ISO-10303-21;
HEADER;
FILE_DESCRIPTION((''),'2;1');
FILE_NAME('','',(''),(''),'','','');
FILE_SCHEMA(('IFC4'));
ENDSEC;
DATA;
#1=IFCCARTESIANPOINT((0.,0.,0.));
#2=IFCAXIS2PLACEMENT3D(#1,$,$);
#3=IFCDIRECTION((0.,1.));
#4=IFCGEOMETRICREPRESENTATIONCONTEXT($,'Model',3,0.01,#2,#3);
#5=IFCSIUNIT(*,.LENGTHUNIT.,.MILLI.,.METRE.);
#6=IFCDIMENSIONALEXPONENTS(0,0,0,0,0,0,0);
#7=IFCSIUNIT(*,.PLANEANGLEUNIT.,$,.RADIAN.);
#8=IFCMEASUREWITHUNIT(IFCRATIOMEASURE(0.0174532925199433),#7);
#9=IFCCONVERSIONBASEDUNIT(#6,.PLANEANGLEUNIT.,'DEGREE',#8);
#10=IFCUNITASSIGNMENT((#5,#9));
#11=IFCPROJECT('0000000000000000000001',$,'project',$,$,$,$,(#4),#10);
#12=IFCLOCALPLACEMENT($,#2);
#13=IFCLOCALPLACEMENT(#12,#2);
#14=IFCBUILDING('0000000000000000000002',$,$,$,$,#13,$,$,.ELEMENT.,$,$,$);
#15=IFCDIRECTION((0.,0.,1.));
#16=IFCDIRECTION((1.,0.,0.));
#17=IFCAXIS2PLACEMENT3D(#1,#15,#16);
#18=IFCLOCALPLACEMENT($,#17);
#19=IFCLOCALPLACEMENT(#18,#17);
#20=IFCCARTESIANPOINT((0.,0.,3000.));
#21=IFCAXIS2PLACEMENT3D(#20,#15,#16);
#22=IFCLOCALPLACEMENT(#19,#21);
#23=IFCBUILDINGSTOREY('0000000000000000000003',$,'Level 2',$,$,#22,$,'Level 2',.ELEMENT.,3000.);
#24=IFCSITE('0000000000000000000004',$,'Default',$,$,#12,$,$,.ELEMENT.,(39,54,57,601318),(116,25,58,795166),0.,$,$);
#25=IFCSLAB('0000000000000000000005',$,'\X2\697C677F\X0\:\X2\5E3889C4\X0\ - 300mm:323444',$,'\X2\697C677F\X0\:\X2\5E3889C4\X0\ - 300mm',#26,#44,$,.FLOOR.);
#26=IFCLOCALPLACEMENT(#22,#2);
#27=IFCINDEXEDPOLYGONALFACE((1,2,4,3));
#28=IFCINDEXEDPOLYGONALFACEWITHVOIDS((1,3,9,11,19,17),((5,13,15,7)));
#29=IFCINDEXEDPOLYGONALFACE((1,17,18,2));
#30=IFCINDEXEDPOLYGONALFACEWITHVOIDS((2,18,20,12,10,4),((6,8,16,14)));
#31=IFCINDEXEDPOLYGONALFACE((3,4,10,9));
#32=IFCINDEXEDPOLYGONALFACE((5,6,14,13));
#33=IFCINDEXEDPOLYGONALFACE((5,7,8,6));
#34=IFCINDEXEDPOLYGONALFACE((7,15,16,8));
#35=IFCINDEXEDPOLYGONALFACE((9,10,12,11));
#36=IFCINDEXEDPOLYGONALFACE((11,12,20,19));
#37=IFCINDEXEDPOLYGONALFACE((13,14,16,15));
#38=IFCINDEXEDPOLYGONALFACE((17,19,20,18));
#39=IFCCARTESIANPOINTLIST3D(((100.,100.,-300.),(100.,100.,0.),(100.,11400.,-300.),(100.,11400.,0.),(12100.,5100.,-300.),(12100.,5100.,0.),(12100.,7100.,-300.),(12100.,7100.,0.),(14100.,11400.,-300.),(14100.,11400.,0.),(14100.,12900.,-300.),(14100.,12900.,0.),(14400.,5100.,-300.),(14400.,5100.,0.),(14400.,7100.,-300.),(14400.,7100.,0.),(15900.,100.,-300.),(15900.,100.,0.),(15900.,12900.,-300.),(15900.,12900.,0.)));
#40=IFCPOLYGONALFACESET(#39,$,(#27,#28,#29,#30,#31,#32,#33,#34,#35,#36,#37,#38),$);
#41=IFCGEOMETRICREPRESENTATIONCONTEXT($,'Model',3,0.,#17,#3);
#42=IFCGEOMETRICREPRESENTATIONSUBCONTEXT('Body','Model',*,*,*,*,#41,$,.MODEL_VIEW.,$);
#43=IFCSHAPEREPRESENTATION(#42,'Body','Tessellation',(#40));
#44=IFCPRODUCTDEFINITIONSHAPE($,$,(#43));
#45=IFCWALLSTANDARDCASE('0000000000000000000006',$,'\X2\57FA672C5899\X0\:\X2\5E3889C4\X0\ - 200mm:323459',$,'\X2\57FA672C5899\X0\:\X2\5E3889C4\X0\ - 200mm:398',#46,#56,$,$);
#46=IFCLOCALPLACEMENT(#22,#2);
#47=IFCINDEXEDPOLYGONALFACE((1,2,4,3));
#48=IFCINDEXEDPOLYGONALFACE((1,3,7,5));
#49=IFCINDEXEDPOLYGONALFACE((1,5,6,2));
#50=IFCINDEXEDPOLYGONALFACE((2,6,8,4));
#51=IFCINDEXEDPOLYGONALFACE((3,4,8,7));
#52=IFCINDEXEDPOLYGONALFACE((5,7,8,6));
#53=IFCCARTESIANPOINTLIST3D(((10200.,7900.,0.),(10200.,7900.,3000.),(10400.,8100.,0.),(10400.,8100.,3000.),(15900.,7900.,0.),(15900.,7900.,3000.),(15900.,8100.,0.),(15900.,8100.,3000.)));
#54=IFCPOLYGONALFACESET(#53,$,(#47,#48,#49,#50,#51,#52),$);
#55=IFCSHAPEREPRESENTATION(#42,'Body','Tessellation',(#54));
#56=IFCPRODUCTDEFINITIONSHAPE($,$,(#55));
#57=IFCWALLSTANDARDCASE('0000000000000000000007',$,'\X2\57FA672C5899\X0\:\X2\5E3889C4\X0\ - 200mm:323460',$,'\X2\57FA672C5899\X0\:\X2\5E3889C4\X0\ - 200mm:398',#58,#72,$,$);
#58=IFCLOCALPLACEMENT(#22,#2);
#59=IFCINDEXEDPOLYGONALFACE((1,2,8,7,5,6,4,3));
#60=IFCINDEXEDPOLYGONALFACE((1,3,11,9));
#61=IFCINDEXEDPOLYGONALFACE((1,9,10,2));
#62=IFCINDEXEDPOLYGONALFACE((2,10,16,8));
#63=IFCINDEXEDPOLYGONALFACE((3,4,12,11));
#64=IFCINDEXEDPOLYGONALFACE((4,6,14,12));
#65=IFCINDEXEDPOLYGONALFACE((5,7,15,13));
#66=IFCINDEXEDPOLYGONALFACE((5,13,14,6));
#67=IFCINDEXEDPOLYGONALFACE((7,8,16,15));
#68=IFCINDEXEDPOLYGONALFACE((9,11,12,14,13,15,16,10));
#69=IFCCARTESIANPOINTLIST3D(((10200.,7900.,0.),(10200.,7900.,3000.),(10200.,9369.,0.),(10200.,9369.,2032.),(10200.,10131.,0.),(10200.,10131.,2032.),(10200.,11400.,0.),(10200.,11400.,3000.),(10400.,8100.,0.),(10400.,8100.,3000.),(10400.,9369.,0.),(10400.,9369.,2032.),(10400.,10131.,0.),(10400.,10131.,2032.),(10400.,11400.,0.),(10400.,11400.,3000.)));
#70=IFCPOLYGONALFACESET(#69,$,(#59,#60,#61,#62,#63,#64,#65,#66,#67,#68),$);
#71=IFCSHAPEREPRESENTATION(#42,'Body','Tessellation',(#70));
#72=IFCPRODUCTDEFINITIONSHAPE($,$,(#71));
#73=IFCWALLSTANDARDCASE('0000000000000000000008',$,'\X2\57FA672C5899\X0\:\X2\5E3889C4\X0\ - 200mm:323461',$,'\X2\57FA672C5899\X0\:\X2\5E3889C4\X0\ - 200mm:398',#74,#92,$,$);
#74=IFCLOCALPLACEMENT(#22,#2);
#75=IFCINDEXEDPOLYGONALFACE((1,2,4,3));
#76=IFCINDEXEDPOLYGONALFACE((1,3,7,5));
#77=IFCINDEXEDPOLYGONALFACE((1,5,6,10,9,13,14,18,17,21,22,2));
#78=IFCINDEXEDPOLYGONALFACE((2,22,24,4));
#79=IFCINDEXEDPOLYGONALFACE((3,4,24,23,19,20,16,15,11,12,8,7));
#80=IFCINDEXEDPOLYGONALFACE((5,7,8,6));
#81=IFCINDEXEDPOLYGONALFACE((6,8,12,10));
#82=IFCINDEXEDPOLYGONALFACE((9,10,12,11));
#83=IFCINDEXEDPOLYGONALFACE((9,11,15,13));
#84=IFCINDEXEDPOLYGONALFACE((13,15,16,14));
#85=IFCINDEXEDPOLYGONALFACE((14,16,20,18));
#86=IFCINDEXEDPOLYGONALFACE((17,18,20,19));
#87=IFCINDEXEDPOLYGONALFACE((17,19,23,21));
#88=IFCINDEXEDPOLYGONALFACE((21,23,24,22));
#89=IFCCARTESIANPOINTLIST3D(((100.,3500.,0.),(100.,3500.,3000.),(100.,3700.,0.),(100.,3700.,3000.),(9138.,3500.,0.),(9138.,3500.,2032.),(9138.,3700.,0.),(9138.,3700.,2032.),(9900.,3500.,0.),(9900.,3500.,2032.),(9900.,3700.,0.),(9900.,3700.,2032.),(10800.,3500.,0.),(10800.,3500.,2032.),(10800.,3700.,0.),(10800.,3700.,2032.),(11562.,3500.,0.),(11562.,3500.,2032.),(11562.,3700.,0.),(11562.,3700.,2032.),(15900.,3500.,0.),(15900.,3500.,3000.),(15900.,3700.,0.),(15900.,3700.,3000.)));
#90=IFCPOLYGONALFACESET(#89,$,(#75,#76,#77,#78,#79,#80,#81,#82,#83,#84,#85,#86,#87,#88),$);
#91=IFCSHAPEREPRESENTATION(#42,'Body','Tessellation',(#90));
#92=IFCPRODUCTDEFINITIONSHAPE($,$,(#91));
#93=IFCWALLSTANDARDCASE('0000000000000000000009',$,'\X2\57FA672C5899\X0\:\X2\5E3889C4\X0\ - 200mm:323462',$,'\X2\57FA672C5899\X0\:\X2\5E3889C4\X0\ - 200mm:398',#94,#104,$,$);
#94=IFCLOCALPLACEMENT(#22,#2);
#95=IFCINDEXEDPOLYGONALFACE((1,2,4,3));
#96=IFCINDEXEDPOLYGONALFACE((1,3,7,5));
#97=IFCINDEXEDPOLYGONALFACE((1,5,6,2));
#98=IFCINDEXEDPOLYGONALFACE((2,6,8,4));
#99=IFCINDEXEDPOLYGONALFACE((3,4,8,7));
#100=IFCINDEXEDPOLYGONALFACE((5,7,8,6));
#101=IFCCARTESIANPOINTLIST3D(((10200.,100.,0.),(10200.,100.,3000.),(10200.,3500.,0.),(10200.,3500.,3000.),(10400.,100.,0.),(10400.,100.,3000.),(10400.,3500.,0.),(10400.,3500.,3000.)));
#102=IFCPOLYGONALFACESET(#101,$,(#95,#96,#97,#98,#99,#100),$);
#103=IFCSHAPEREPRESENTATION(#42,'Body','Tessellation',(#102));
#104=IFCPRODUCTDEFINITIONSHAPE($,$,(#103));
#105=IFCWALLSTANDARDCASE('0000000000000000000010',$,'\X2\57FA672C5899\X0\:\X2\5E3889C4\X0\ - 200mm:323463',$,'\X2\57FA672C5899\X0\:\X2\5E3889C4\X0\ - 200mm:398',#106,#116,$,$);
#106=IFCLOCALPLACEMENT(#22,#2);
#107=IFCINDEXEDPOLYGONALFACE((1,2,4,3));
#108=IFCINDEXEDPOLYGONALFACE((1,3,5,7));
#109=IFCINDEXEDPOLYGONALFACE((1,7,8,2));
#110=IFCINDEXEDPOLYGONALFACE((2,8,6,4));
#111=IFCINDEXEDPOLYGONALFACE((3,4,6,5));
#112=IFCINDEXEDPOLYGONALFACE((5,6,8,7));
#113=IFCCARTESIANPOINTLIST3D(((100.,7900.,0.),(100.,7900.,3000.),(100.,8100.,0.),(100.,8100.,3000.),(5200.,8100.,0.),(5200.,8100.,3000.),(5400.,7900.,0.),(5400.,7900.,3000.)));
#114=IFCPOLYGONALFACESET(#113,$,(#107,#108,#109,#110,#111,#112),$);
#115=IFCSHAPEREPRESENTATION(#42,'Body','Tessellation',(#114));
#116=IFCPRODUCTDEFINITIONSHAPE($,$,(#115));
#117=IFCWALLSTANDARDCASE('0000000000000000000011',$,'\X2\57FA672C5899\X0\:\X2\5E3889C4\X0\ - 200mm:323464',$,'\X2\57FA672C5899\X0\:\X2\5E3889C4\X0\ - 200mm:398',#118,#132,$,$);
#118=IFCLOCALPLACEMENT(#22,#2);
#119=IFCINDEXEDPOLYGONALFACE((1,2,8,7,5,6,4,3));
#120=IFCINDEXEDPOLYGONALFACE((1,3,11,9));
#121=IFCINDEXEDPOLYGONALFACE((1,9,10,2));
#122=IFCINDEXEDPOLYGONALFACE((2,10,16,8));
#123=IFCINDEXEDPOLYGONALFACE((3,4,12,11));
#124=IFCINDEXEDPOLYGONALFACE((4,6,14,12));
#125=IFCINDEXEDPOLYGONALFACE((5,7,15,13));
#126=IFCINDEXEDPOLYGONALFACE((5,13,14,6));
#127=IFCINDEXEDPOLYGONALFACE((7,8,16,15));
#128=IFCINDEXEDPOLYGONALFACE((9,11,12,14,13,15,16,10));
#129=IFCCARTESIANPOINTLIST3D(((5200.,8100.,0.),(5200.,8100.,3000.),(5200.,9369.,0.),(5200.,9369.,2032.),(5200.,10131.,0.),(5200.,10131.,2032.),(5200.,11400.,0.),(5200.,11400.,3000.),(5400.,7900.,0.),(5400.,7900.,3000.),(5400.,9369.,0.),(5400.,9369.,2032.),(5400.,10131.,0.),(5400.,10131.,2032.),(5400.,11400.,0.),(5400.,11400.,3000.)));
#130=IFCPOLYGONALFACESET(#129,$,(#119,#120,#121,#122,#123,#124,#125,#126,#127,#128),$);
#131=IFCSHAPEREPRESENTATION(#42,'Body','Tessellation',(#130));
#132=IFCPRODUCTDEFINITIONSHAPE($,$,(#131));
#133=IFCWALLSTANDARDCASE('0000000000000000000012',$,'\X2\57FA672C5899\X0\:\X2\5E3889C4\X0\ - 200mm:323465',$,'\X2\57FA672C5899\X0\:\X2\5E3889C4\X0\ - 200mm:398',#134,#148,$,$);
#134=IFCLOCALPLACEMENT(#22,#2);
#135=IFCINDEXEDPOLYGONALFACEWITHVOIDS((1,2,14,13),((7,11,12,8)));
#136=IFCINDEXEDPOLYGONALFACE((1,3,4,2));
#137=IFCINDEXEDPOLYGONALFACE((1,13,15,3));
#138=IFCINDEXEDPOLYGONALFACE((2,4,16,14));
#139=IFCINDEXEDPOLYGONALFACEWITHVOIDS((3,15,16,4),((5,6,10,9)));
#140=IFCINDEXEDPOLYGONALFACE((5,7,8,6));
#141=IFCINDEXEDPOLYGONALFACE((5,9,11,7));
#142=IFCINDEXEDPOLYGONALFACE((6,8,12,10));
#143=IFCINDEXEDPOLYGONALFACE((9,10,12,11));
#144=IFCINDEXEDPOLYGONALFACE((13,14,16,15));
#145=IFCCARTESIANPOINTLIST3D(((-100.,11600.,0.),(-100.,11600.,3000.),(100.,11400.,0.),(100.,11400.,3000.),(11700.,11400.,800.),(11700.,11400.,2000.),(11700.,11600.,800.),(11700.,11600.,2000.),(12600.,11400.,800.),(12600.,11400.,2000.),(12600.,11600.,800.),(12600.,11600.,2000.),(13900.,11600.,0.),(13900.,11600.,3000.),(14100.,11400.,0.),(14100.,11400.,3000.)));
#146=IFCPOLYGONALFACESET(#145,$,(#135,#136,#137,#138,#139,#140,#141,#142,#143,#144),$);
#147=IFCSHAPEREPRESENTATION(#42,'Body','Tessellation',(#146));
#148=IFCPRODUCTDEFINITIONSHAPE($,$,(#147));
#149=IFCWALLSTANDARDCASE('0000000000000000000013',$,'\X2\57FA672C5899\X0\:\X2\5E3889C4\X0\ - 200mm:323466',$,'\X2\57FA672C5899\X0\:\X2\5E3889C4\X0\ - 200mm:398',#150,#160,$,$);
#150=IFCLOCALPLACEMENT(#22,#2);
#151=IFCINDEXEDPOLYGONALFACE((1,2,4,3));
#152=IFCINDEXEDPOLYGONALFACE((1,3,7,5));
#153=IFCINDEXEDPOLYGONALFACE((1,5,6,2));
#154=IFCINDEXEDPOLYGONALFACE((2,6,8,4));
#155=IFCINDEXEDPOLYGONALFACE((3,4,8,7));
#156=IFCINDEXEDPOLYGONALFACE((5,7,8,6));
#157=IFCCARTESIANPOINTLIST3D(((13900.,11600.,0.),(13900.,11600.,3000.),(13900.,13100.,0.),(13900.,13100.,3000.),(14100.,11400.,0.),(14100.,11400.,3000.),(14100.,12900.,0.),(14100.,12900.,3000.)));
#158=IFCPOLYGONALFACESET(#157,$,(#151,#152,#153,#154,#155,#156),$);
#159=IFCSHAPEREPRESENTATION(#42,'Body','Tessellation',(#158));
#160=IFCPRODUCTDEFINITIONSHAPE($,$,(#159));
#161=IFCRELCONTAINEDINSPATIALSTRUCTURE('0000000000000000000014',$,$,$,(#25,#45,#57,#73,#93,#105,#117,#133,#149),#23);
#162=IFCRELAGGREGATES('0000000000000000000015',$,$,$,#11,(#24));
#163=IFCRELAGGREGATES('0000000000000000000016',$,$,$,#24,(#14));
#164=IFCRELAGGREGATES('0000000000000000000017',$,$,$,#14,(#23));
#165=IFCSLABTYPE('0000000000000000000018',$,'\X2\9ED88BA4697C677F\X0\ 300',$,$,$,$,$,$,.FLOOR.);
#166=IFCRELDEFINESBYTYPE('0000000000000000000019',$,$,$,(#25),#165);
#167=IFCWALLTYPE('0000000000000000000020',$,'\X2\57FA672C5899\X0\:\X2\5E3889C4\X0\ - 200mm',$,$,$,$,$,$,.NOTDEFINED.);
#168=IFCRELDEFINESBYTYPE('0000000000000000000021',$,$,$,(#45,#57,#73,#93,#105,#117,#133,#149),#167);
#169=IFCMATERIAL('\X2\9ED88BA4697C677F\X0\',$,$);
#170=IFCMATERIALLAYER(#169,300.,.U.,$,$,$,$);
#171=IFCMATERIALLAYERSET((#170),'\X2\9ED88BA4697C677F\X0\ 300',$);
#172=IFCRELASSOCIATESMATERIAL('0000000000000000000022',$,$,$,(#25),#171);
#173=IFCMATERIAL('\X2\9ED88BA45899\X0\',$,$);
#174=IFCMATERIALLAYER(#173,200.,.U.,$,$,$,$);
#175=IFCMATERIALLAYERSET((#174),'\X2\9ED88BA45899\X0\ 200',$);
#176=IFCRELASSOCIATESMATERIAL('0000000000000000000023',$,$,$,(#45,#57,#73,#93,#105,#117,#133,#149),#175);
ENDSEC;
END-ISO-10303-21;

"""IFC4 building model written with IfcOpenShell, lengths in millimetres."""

from ifc_helpers import new_model, entity, si_unit, converted_unit, direction, frame, origin, origin_with_axes, place, context, subcontext, project, spatial, polyline, outline, extrude, material, layer, layer_set, layer_usage, type_object, element, save


model = new_model("IFC4")

# Units and contexts
model_context_1 = context("Model", 3, precision=0.01, world=origin(), true_north=direction((0.0, 1.0)))
model_context_2 = context("Model", 3, precision=0.0, world=origin_with_axes(), true_north=direction((0.0, 1.0)))
body_context = subcontext(model_context_2, "Body", "Model", "MODEL_VIEW")
ifc_project = project(units=[si_unit("LENGTHUNIT", "METRE", prefix="MILLI"), converted_unit("PLANEANGLEUNIT", "DEGREE", entity("IfcRatioMeasure", 0.0174532925199433), si_unit("PLANEANGLEUNIT", "RADIAN"), dimensions=[0, 0, 0, 0, 0, 0, 0])], contexts=[model_context_1])

# Site, building, storey
site_placement = place(None, origin())
site = spatial("IfcSite", under=ifc_project, at=site_placement, Name="Default", CompositionType="ELEMENT", RefLatitude=(39, 54, 57, 601318), RefLongitude=(116, 25, 58, 795166), RefElevation=0.0)
building_placement = place(site_placement, origin())
building = spatial("IfcBuilding", under=site, at=building_placement, CompositionType="ELEMENT")
placement_1 = place(None, origin_with_axes())
placement_2 = place(placement_1, origin_with_axes())
storey_placement = place(placement_2, frame((0.0, 0.0, 3000.0), z_axis=(0.0, 0.0, 1.0), x_axis=(1.0, 0.0, 0.0)))
storey = spatial("IfcBuildingStorey", under=building, at=storey_placement, Name="Level 2", LongName="Level 2", CompositionType="ELEMENT", Elevation=3000.0)

# Slab, opening
ifc_material_1 = material(Name="默认楼板")
ifc_layer_1 = layer(ifc_material_1, 300.0, ventilated="UNKNOWN")
ifc_layer_set_1 = layer_set([ifc_layer_1], Name="默认楼板 300")
ifc_layer_usage_1 = layer_usage(ifc_layer_set_1, "AXIS3", "NEGATIVE", 300.0)
slab_type = type_object("IfcSlabType", Name="默认楼板 300", PredefinedType="FLOOR")
slab_placement = place(storey_placement, frame((15900.0, 12900.0, -300.0), z_axis=(0.0, 0.0, 1.0), x_axis=(1.0, 0.0, 0.0)))
slab = element("IfcSlab", 1, at=slab_placement, inside=storey, type_object=slab_type, material=ifc_layer_usage_1, Name="楼板:常规 - 300mm:323444", ObjectType="楼板:常规 - 300mm", PredefinedType="FLOOR", context=body_context, shape_type="SweptSolid", body=[
    extrude(outline(polyline([(0.0, 0.0), (-1800.0, 0.0), (-1800.0, -1500.0), (-15800.0, -1500.0), (-15800.0, -12800.0), (0.0, -12800.0), (0.0, 0.0)])), origin_with_axes(), (0.0, 0.0, 1.0), 300.0),
])
opening_1_placement = place(slab_placement, origin_with_axes())
element("IfcOpeningElement", 2, at=opening_1_placement, cuts=slab, context=body_context, shape_type="SweptSolid", body=[
    extrude(outline(polyline([(-3800.0, -7800.0), (-1500.0, -7800.0), (-1500.0, -5800.0), (-3800.0, -5800.0), (-3800.0, -7800.0)])), origin_with_axes(), (0.0, 0.0, 1.0), 300.0),
])

# Wall
ifc_material_2 = material(Name="默认墙")
ifc_layer_2 = layer(ifc_material_2, 200.0, ventilated="UNKNOWN")
ifc_layer_set_2 = layer_set([ifc_layer_2], Name="默认墙 200")
ifc_layer_usage_2 = layer_usage(ifc_layer_set_2, "AXIS2", "POSITIVE", -100.0)
wall_type = type_object("IfcWallType", Name="基本墙:常规 - 200mm", PredefinedType="NOTDEFINED")
wall_1_placement = place(storey_placement, frame((10300.0, 8000.0, 0.0), z_axis=(0.0, 0.0, 1.0), x_axis=(1.0, 0.0, 0.0)))
element("IfcWallStandardCase", 3, at=wall_1_placement, inside=storey, type_object=wall_type, material=ifc_layer_usage_2, Name="基本墙:常规 - 200mm:323459", ObjectType="基本墙:常规 - 200mm:398", context=body_context, shape_type="SweptSolid", body=[
    extrude(outline(polyline([(-100.0, -100.0), (5600.0, -100.0), (5600.0, 100.0), (100.0, 100.0), (-100.0, -100.0)])), origin_with_axes(), (0.0, 0.0, 1.0), 3000.0),
])

# Wall, opening
ifc_layer_usage_3 = layer_usage(ifc_layer_set_2, "AXIS2", "POSITIVE", -100.0)
wall_2_placement = place(storey_placement, frame((10300.0, 11500.0, 0.0), z_axis=(0.0, 0.0, 1.0), x_axis=(0.0, -1.0, 0.0)))
wall_2 = element("IfcWallStandardCase", 4, at=wall_2_placement, inside=storey, type_object=wall_type, material=ifc_layer_usage_3, Name="基本墙:常规 - 200mm:323460", ObjectType="基本墙:常规 - 200mm:398", context=body_context, shape_type="SweptSolid", body=[
    extrude(outline(polyline([(100.0, -100.0), (3600.0, -100.0), (3400.0, 100.0), (100.0, 100.0), (100.0, -100.0)])), origin_with_axes(), (0.0, 0.0, 1.0), 3000.0),
])
opening_2_placement = place(wall_2_placement, frame((1750.0, 0.0, 0.0), z_axis=(0.0, 0.0, 1.0), x_axis=(1.0, 0.0, 0.0)))
element("IfcOpeningElement", 5, at=opening_2_placement, cuts=wall_2, context=body_context, shape_type="SweptSolid", body=[
    extrude(outline(polyline([(-381.0, -2032.0), (381.0, -2032.0), (381.0, 0.0), (-381.0, 0.0), (-381.0, -2032.0)])), frame((0.0, 100.0, 0.0), z_axis=(0.0, -1.0, 0.0), x_axis=(-1.0, 0.0, 0.0)), (0.0, 0.0, 1.0), 200.0),
])

# Wall, openings
ifc_layer_usage_4 = layer_usage(ifc_layer_set_2, "AXIS2", "POSITIVE", -100.0)
wall_3_placement = place(storey_placement, frame((16000.0, 3600.0, 0.0), z_axis=(0.0, 0.0, 1.0), x_axis=(-1.0, 0.0, 0.0)))
wall_3 = element("IfcWallStandardCase", 6, at=wall_3_placement, inside=storey, type_object=wall_type, material=ifc_layer_usage_4, Name="基本墙:常规 - 200mm:323461", ObjectType="基本墙:常规 - 200mm:398", context=body_context, shape_type="SweptSolid", body=[
    extrude(outline(polyline([(100.0, -100.0), (15900.0, -100.0), (15900.0, 100.0), (100.0, 100.0), (100.0, -100.0)])), origin_with_axes(), (0.0, 0.0, 1.0), 3000.0),
])
opening_3_placement = place(wall_3_placement, frame((6481.0, 0.0, 0.0), z_axis=(0.0, 0.0, 1.0), x_axis=(1.0, 0.0, 0.0)))
element("IfcOpeningElement", 7, at=opening_3_placement, cuts=wall_3, context=body_context, shape_type="SweptSolid", body=[
    extrude(outline(polyline([(-381.0, 0.0), (-381.0, -2032.0), (381.0, -2032.0), (381.0, 0.0), (-381.0, 0.0)])), frame((0.0, 100.0, 0.0), z_axis=(0.0, 1.0, 0.0), x_axis=(1.0, 0.0, 0.0)), (0.0, 0.0, -1.0), 200.0),
])
opening_4_placement = place(wall_3_placement, frame((4819.0, 0.0, 0.0), z_axis=(0.0, 0.0, 1.0), x_axis=(1.0, 0.0, 0.0)))
element("IfcOpeningElement", 8, at=opening_4_placement, cuts=wall_3, context=body_context, shape_type="SweptSolid", body=[
    extrude(outline(polyline([(-381.0, -2032.0), (381.0, -2032.0), (381.0, 0.0), (-381.0, 0.0), (-381.0, -2032.0)])), frame((0.0, 100.0, 0.0), z_axis=(0.0, -1.0, 0.0), x_axis=(-1.0, 0.0, 0.0)), (0.0, 0.0, 1.0), 200.0),
])

# Walls
ifc_layer_usage_5 = layer_usage(ifc_layer_set_2, "AXIS2", "POSITIVE", -100.0)
wall_4_placement = place(storey_placement, frame((10300.0, 3600.0, 0.0), z_axis=(0.0, 0.0, 1.0), x_axis=(0.0, -1.0, 0.0)))
element("IfcWallStandardCase", 9, at=wall_4_placement, inside=storey, type_object=wall_type, material=ifc_layer_usage_5, Name="基本墙:常规 - 200mm:323462", ObjectType="基本墙:常规 - 200mm:398", context=body_context, shape_type="SweptSolid", body=[
    extrude(outline(polyline([(100.0, -100.0), (3500.0, -100.0), (3500.0, 100.0), (100.0, 100.0), (100.0, -100.0)])), origin_with_axes(), (0.0, 0.0, 1.0), 3000.0),
])
ifc_layer_usage_6 = layer_usage(ifc_layer_set_2, "AXIS2", "POSITIVE", -100.0)
wall_5_placement = place(storey_placement, frame((0.0, 8000.0, 0.0), z_axis=(0.0, 0.0, 1.0), x_axis=(1.0, 0.0, 0.0)))
element("IfcWallStandardCase", 10, at=wall_5_placement, inside=storey, type_object=wall_type, material=ifc_layer_usage_6, Name="基本墙:常规 - 200mm:323463", ObjectType="基本墙:常规 - 200mm:398", context=body_context, shape_type="SweptSolid", body=[
    extrude(outline(polyline([(100.0, -100.0), (5400.0, -100.0), (5200.0, 100.0), (100.0, 100.0), (100.0, -100.0)])), origin_with_axes(), (0.0, 0.0, 1.0), 3000.0),
])

# Walls, openings
ifc_layer_usage_7 = layer_usage(ifc_layer_set_2, "AXIS2", "POSITIVE", -100.0)
wall_6_placement = place(storey_placement, frame((5300.0, 8000.0, 0.0), z_axis=(0.0, 0.0, 1.0), x_axis=(0.0, 1.0, 0.0)))
wall_6 = element("IfcWallStandardCase", 11, at=wall_6_placement, inside=storey, type_object=wall_type, material=ifc_layer_usage_7, Name="基本墙:常规 - 200mm:323464", ObjectType="基本墙:常规 - 200mm:398", context=body_context, shape_type="SweptSolid", body=[
    extrude(outline(polyline([(-100.0, -100.0), (3400.0, -100.0), (3400.0, 100.0), (100.0, 100.0), (-100.0, -100.0)])), origin_with_axes(), (0.0, 0.0, 1.0), 3000.0),
])
opening_5_placement = place(wall_6_placement, frame((1750.0, 0.0, 0.0), z_axis=(0.0, 0.0, 1.0), x_axis=(1.0, 0.0, 0.0)))
element("IfcOpeningElement", 12, at=opening_5_placement, cuts=wall_6, context=body_context, shape_type="SweptSolid", body=[
    extrude(outline(polyline([(-381.0, -2032.0), (381.0, -2032.0), (381.0, 0.0), (-381.0, 0.0), (-381.0, -2032.0)])), frame((0.0, 100.0, 0.0), z_axis=(0.0, -1.0, 0.0), x_axis=(-1.0, 0.0, 0.0)), (0.0, 0.0, 1.0), 200.0),
])
ifc_layer_usage_8 = layer_usage(ifc_layer_set_2, "AXIS2", "POSITIVE", -100.0)
wall_7_placement = place(storey_placement, frame((0.0, 11500.0, 0.0), z_axis=(0.0, 0.0, 1.0), x_axis=(1.0, 0.0, 0.0)))
wall_7 = element("IfcWallStandardCase", 13, at=wall_7_placement, inside=storey, type_object=wall_type, material=ifc_layer_usage_8, Name="基本墙:常规 - 200mm:323465", ObjectType="基本墙:常规 - 200mm:398", context=body_context, shape_type="SweptSolid", body=[
    extrude(outline(polyline([(100.0, -100.0), (14100.0, -100.0), (13900.0, 100.0), (-100.0, 100.0), (100.0, -100.0)])), origin_with_axes(), (0.0, 0.0, 1.0), 3000.0),
])
opening_6_placement = place(wall_7_placement, frame((12150.0, 0.0, 800.0), z_axis=(0.0, 0.0, 1.0), x_axis=(1.0, 0.0, 0.0)))
element("IfcOpeningElement", 14, at=opening_6_placement, cuts=wall_7, context=body_context, shape_type="SweptSolid", body=[
    extrude(outline(polyline([(450.0, -1200.0), (450.0, 0.0), (-450.0, 0.0), (-450.0, -1200.0), (450.0, -1200.0)])), frame((0.0, 100.0, 0.0), z_axis=(0.0, -1.0, 0.0), x_axis=(-1.0, 0.0, 0.0)), (0.0, 0.0, 1.0), 200.0),
])

# Wall
ifc_layer_usage_9 = layer_usage(ifc_layer_set_2, "AXIS2", "POSITIVE", -100.0)
wall_8_placement = place(storey_placement, frame((14000.0, 11500.0, 0.0), z_axis=(0.0, 0.0, 1.0), x_axis=(0.0, 1.0, 0.0)))
element("IfcWallStandardCase", 15, at=wall_8_placement, inside=storey, type_object=wall_type, material=ifc_layer_usage_9, Name="基本墙:常规 - 200mm:323466", ObjectType="基本墙:常规 - 200mm:398", context=body_context, shape_type="SweptSolid", body=[
    extrude(outline(polyline([(-100.0, -100.0), (1400.0, -100.0), (1600.0, 100.0), (100.0, 100.0), (-100.0, -100.0)])), origin_with_axes(), (0.0, 0.0, 1.0), 3000.0),
])

save(model, "model.ifc")
